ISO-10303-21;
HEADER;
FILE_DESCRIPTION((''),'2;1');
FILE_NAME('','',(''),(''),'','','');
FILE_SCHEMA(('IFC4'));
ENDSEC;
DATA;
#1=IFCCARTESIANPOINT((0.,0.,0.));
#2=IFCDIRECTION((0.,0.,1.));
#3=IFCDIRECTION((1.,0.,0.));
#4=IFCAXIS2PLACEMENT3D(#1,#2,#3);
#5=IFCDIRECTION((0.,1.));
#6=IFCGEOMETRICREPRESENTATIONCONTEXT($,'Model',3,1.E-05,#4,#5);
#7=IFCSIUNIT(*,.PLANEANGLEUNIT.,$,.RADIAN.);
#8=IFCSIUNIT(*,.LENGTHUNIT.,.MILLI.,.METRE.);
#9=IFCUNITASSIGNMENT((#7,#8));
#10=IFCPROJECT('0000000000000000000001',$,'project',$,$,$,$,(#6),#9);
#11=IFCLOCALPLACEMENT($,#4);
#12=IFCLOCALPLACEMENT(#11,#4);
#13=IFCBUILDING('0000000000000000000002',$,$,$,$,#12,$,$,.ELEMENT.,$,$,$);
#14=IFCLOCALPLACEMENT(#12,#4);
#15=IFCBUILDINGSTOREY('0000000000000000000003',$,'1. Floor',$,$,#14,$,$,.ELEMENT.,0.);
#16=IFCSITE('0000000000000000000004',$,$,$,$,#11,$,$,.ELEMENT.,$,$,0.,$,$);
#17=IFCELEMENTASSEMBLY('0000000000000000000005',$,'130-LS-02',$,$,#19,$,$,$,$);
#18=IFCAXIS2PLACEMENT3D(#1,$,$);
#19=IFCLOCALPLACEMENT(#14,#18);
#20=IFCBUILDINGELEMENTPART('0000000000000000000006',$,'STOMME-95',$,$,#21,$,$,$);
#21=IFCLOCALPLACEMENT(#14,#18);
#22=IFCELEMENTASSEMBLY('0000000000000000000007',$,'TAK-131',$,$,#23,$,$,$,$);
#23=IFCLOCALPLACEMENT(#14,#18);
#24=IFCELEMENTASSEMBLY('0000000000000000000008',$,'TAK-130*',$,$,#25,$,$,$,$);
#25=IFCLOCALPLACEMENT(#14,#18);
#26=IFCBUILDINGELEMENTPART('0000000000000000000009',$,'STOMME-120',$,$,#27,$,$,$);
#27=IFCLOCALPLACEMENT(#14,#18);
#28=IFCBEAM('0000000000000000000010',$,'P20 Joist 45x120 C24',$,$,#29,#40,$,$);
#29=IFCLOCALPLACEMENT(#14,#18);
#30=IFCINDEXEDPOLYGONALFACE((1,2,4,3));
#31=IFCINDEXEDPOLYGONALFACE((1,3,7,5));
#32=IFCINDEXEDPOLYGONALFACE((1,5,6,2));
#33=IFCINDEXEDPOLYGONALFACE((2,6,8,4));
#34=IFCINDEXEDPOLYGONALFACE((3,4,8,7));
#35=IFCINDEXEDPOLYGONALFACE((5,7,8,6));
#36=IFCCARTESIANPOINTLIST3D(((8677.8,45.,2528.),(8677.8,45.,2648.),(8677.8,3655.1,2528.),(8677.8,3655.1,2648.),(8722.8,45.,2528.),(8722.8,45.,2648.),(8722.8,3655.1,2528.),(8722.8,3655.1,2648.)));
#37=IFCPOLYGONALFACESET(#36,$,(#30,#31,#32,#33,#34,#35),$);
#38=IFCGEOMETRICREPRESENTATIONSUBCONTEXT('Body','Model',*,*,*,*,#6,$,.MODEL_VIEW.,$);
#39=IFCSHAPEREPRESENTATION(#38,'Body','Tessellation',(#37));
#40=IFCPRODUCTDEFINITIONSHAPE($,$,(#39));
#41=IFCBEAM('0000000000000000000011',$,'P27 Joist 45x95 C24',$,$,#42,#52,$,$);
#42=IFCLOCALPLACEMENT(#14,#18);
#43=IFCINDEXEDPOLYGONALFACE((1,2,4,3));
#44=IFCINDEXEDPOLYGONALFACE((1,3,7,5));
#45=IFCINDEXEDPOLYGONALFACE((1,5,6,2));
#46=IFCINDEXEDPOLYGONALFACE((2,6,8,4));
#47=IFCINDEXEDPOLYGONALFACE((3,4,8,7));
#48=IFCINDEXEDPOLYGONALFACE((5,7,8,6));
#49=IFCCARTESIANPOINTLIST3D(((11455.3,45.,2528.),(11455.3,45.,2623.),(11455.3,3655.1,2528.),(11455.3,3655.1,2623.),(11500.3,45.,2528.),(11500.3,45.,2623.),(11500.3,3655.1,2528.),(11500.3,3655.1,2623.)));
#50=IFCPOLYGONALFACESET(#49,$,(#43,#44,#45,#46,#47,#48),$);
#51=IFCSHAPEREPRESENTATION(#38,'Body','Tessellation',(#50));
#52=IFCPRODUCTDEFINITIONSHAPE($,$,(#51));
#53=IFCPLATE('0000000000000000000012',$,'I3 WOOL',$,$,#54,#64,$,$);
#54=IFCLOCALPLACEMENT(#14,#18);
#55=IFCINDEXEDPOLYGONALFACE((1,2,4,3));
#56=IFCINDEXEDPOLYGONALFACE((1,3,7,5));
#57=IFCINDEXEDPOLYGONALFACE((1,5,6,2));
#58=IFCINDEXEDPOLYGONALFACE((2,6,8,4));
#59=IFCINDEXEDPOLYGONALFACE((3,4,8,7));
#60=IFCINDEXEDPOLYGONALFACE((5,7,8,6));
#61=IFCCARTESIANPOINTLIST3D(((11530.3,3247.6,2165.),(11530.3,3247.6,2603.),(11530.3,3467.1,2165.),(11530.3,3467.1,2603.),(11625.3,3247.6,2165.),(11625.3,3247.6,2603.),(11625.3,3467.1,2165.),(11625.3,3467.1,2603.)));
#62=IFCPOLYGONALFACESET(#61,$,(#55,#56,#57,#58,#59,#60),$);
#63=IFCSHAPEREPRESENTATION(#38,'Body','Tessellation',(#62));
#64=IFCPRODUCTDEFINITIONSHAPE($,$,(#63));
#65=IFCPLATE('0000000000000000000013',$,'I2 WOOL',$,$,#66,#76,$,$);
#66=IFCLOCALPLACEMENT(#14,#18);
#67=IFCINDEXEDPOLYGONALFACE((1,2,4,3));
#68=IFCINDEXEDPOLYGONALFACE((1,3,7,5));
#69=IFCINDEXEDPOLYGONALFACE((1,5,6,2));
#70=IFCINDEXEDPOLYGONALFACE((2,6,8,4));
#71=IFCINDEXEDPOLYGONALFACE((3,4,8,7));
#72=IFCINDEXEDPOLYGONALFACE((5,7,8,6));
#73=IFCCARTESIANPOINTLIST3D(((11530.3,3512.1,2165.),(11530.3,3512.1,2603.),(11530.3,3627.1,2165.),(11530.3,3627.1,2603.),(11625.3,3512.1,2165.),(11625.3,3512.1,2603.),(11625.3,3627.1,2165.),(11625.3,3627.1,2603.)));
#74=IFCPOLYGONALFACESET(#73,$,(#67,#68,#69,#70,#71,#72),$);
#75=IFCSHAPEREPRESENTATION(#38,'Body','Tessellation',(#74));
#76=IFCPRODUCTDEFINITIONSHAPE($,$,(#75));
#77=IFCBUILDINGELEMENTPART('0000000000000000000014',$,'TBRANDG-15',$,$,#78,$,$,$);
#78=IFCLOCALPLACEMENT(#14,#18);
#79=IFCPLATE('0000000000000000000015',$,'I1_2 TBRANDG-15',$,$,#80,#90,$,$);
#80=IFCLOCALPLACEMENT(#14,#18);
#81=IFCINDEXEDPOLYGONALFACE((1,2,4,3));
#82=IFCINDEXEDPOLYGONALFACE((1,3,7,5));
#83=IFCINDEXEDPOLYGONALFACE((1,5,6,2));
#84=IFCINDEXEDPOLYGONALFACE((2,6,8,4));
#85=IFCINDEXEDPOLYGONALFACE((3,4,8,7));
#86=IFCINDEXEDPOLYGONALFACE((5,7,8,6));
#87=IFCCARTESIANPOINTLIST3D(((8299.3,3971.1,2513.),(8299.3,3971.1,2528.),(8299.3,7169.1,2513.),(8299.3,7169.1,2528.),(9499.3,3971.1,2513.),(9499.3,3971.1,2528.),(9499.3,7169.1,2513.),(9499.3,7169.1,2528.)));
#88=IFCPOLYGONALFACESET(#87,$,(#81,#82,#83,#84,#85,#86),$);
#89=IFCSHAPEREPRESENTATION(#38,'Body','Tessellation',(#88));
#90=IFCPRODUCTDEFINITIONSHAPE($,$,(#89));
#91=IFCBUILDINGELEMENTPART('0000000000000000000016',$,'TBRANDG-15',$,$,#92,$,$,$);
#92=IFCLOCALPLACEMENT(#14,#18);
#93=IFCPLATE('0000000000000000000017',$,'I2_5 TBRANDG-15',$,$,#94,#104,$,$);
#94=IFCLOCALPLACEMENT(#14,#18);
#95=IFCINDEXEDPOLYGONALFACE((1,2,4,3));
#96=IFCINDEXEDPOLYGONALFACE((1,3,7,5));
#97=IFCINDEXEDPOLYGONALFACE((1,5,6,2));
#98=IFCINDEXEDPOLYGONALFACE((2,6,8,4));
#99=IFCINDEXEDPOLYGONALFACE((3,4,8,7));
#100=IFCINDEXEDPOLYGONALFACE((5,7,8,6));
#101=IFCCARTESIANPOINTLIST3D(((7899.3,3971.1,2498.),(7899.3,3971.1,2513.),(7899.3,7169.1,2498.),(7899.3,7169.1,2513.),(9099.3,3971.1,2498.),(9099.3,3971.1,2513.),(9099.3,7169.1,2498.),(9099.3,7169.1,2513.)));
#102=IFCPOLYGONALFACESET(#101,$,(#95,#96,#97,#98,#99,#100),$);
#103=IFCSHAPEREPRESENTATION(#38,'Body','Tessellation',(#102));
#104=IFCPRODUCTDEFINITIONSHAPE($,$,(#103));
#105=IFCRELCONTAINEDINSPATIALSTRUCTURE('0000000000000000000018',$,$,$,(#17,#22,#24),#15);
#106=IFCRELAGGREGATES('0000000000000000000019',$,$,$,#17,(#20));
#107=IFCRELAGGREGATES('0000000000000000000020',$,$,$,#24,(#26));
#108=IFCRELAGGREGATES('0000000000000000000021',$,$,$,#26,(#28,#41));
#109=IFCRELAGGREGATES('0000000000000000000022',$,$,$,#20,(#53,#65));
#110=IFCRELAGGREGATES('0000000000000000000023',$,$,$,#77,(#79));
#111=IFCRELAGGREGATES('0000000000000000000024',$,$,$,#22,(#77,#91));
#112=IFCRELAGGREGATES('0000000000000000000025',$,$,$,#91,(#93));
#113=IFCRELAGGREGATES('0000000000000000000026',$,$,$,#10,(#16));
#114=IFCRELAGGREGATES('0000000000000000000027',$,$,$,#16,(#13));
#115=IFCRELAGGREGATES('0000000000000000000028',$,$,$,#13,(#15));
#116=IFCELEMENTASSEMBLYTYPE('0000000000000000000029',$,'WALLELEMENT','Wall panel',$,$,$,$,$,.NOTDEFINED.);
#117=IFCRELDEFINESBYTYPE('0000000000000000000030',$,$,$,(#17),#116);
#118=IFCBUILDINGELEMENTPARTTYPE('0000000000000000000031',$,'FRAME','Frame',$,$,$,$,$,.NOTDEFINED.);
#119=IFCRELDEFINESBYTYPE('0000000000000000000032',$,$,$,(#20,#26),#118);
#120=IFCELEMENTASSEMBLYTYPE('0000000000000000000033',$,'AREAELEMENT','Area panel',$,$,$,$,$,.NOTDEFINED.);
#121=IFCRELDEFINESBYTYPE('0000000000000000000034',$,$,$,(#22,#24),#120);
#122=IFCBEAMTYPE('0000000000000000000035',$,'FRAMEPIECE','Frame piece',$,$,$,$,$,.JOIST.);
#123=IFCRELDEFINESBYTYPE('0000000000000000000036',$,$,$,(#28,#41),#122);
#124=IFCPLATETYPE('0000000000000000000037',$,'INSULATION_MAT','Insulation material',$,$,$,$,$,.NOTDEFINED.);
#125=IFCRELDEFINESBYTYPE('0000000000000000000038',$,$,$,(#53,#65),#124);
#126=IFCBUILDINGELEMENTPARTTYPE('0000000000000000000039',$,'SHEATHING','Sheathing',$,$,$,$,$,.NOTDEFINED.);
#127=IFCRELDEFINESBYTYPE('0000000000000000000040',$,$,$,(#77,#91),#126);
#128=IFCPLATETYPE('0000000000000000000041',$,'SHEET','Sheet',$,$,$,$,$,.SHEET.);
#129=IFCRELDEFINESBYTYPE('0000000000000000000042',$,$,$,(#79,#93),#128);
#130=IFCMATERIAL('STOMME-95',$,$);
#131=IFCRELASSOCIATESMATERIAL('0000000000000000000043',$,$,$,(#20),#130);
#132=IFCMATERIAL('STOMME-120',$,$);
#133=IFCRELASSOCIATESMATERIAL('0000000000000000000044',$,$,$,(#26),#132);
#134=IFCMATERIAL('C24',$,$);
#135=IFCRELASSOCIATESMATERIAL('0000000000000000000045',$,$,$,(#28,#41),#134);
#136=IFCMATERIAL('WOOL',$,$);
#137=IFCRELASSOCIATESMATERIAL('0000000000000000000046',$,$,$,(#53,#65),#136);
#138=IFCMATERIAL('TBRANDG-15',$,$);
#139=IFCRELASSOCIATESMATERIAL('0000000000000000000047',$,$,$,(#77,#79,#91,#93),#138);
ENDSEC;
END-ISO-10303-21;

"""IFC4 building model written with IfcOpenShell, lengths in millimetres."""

from ifc_helpers import new_model, si_unit, direction, frame, origin_with_axes, origin_2d_with_axis, place, context, subcontext, project, spatial, rectangle, extrude, material, type_object, element, aggregate, save


model = new_model("IFC4")

# Units and contexts
model_context = context("Model", 3, precision=1e-05, world=origin_with_axes(), true_north=direction((0.0, 1.0)))
body_context = subcontext(model_context, "Body", "Model", "MODEL_VIEW")
ifc_project = project(units=[si_unit("PLANEANGLEUNIT", "RADIAN"), si_unit("LENGTHUNIT", "METRE", prefix="MILLI")], contexts=[model_context])

# Site, building, storey
site_placement = place(None, origin_with_axes())
site = spatial("IfcSite", under=ifc_project, at=site_placement, CompositionType="ELEMENT", RefElevation=0.0)
building_placement = place(site_placement, origin_with_axes())
building = spatial("IfcBuilding", under=site, at=building_placement, CompositionType="ELEMENT")
storey_placement = place(building_placement, origin_with_axes())
storey = spatial("IfcBuildingStorey", under=building, at=storey_placement, Name="1. Floor", CompositionType="ELEMENT", Elevation=0.0)

# Shared definitions
element_assembly_type_1 = type_object("IfcElementAssemblyType", Name="WALLELEMENT", Description="Wall panel", PredefinedType="NOTDEFINED")
ifc_material_1 = material(Name="STOMME-95")
building_element_part_type_1 = type_object("IfcBuildingElementPartType", Name="FRAME", Description="Frame", PredefinedType="NOTDEFINED")

# Element assembly, building element part
ifc_material_2 = material(Name="C24")
assembly_1_placement = place(storey_placement, origin_with_axes())
assembly_1 = element("IfcElementAssembly", 1, at=assembly_1_placement, inside=storey, type_object=element_assembly_type_1, Name="130-LS-02")
building_element_part_1_placement = place(storey_placement, origin_with_axes())
building_element_part_1 = element("IfcBuildingElementPart", 2, at=building_element_part_1_placement, type_object=building_element_part_type_1, material=ifc_material_1, Name="STOMME-95")
aggregate(assembly_1, [building_element_part_1])

# Element assembly
element_assembly_type_2 = type_object("IfcElementAssemblyType", Name="AREAELEMENT", Description="Area panel", PredefinedType="NOTDEFINED")
assembly_2_placement = place(storey_placement, origin_with_axes())
assembly_2 = element("IfcElementAssembly", 3, at=assembly_2_placement, inside=storey, type_object=element_assembly_type_2, Name="TAK-131")
ifc_material_3 = material(Name="STOMME-120")

# Element assembly, building element part, beams
assembly_3_placement = place(storey_placement, origin_with_axes())
assembly_3 = element("IfcElementAssembly", 4, at=assembly_3_placement, inside=storey, type_object=element_assembly_type_2, Name="TAK-130*")
building_element_part_2_placement = place(storey_placement, origin_with_axes())
building_element_part_2 = element("IfcBuildingElementPart", 5, at=building_element_part_2_placement, type_object=building_element_part_type_1, material=ifc_material_3, Name="STOMME-120")
aggregate(assembly_3, [building_element_part_2])
beam_type_1 = type_object("IfcBeamType", Name="FRAMEPIECE", Description="Frame piece", PredefinedType="JOIST")
beam_1_placement = place(storey_placement, frame((8700.3, 3655.1, 2588.0), z_axis=(0.0, -1.0, 0.0), x_axis=(1.0, 0.0, 0.0)))
beam_1 = element("IfcBeam", 6, at=beam_1_placement, type_object=beam_type_1, material=ifc_material_2, Name="P20 Joist 45x120 C24", context=body_context, shape_type="SweptSolid", body=[
    extrude(rectangle(XDim=45.0, YDim=120.0, at=origin_2d_with_axis()), origin_with_axes(), (0.0, 0.0, 1.0), 3610.1),
])
beam_2_placement = place(storey_placement, frame((11477.8, 3655.1, 2575.5), z_axis=(0.0, -1.0, 0.0), x_axis=(1.0, 0.0, 0.0)))
beam_2 = element("IfcBeam", 7, at=beam_2_placement, type_object=beam_type_1, material=ifc_material_2, Name="P27 Joist 45x95 C24", context=body_context, shape_type="SweptSolid", body=[
    extrude(rectangle(XDim=45.0, YDim=95.0, at=origin_2d_with_axis()), origin_with_axes(), (0.0, 0.0, 1.0), 3610.1),
])
aggregate(building_element_part_2, [beam_1, beam_2])

# Plates
ifc_material_4 = material(Name="WOOL")
plate_type_1 = type_object("IfcPlateType", Name="INSULATION_MAT", Description="Insulation material", PredefinedType="NOTDEFINED")
plate_1_placement = place(storey_placement, frame((11625.3, 3357.4, 2384.0), z_axis=(1.0, 0.0, 0.0), x_axis=(0.0, 1.0, 0.0)))
plate_1 = element("IfcPlate", 8, at=plate_1_placement, type_object=plate_type_1, material=ifc_material_4, Name="I3 WOOL", context=body_context, shape_type="SweptSolid", body=[
    extrude(rectangle(XDim=95.0, YDim=219.5, at=origin_2d_with_axis()), frame((0.0, -219.0, -47.5), z_axis=(0.0, 1.0, 0.0), x_axis=(0.0, 0.0, 1.0)), (0.0, 0.0, 1.0), 438.0),
])
plate_2_placement = place(storey_placement, frame((11625.3, 3569.6, 2384.0), z_axis=(1.0, 0.0, 0.0), x_axis=(0.0, 1.0, 0.0)))
plate_2 = element("IfcPlate", 9, at=plate_2_placement, type_object=plate_type_1, material=ifc_material_4, Name="I2 WOOL", context=body_context, shape_type="SweptSolid", body=[
    extrude(rectangle(XDim=95.0, YDim=115.0, at=origin_2d_with_axis()), frame((0.0, -219.0, -47.5), z_axis=(0.0, 1.0, 0.0), x_axis=(0.0, 0.0, 1.0)), (0.0, 0.0, 1.0), 438.0),
])
aggregate(building_element_part_1, [plate_1, plate_2])

# Building element part, plate
ifc_material_5 = material(Name="TBRANDG-15")
building_element_part_type_2 = type_object("IfcBuildingElementPartType", Name="SHEATHING", Description="Sheathing", PredefinedType="NOTDEFINED")
building_element_part_3_placement = place(storey_placement, origin_with_axes())
building_element_part_3 = element("IfcBuildingElementPart", 10, at=building_element_part_3_placement, type_object=building_element_part_type_2, material=ifc_material_5, Name="TBRANDG-15")
plate_type_2 = type_object("IfcPlateType", Name="SHEET", Description="Sheet", PredefinedType="SHEET")
plate_3_placement = place(storey_placement, frame((8899.3, 4669.1, 2528.0), z_axis=(0.0, 0.0, 1.0), x_axis=(-1.0, 0.0, 0.0)))
plate_3 = element("IfcPlate", 11, at=plate_3_placement, type_object=plate_type_2, material=ifc_material_5, Name="I1_2 TBRANDG-15", context=body_context, shape_type="SweptSolid", body=[
    extrude(rectangle(XDim=15.0, YDim=1200.0, at=origin_2d_with_axis()), frame((0.0, -2500.0, -7.5), z_axis=(0.0, 1.0, 0.0), x_axis=(0.0, 0.0, 1.0)), (0.0, 0.0, 1.0), 3198.0),
])
aggregate(building_element_part_3, [plate_3])

# Building element part
building_element_part_4_placement = place(storey_placement, origin_with_axes())
building_element_part_4 = element("IfcBuildingElementPart", 12, at=building_element_part_4_placement, type_object=building_element_part_type_2, material=ifc_material_5, Name="TBRANDG-15")
aggregate(assembly_2, [building_element_part_3, building_element_part_4])

# Plate
plate_4_placement = place(storey_placement, frame((8499.3, 4669.1, 2513.0), z_axis=(0.0, 0.0, 1.0), x_axis=(-1.0, 0.0, 0.0)))
plate_4 = element("IfcPlate", 13, at=plate_4_placement, type_object=plate_type_2, material=ifc_material_5, Name="I2_5 TBRANDG-15", context=body_context, shape_type="SweptSolid", body=[
    extrude(rectangle(XDim=15.0, YDim=1200.0, at=origin_2d_with_axis()), frame((0.0, -2500.0, -7.5), z_axis=(0.0, 1.0, 0.0), x_axis=(0.0, 0.0, 1.0)), (0.0, 0.0, 1.0), 3198.0),
])
aggregate(building_element_part_4, [plate_4])

save(model, "model.ifc")
